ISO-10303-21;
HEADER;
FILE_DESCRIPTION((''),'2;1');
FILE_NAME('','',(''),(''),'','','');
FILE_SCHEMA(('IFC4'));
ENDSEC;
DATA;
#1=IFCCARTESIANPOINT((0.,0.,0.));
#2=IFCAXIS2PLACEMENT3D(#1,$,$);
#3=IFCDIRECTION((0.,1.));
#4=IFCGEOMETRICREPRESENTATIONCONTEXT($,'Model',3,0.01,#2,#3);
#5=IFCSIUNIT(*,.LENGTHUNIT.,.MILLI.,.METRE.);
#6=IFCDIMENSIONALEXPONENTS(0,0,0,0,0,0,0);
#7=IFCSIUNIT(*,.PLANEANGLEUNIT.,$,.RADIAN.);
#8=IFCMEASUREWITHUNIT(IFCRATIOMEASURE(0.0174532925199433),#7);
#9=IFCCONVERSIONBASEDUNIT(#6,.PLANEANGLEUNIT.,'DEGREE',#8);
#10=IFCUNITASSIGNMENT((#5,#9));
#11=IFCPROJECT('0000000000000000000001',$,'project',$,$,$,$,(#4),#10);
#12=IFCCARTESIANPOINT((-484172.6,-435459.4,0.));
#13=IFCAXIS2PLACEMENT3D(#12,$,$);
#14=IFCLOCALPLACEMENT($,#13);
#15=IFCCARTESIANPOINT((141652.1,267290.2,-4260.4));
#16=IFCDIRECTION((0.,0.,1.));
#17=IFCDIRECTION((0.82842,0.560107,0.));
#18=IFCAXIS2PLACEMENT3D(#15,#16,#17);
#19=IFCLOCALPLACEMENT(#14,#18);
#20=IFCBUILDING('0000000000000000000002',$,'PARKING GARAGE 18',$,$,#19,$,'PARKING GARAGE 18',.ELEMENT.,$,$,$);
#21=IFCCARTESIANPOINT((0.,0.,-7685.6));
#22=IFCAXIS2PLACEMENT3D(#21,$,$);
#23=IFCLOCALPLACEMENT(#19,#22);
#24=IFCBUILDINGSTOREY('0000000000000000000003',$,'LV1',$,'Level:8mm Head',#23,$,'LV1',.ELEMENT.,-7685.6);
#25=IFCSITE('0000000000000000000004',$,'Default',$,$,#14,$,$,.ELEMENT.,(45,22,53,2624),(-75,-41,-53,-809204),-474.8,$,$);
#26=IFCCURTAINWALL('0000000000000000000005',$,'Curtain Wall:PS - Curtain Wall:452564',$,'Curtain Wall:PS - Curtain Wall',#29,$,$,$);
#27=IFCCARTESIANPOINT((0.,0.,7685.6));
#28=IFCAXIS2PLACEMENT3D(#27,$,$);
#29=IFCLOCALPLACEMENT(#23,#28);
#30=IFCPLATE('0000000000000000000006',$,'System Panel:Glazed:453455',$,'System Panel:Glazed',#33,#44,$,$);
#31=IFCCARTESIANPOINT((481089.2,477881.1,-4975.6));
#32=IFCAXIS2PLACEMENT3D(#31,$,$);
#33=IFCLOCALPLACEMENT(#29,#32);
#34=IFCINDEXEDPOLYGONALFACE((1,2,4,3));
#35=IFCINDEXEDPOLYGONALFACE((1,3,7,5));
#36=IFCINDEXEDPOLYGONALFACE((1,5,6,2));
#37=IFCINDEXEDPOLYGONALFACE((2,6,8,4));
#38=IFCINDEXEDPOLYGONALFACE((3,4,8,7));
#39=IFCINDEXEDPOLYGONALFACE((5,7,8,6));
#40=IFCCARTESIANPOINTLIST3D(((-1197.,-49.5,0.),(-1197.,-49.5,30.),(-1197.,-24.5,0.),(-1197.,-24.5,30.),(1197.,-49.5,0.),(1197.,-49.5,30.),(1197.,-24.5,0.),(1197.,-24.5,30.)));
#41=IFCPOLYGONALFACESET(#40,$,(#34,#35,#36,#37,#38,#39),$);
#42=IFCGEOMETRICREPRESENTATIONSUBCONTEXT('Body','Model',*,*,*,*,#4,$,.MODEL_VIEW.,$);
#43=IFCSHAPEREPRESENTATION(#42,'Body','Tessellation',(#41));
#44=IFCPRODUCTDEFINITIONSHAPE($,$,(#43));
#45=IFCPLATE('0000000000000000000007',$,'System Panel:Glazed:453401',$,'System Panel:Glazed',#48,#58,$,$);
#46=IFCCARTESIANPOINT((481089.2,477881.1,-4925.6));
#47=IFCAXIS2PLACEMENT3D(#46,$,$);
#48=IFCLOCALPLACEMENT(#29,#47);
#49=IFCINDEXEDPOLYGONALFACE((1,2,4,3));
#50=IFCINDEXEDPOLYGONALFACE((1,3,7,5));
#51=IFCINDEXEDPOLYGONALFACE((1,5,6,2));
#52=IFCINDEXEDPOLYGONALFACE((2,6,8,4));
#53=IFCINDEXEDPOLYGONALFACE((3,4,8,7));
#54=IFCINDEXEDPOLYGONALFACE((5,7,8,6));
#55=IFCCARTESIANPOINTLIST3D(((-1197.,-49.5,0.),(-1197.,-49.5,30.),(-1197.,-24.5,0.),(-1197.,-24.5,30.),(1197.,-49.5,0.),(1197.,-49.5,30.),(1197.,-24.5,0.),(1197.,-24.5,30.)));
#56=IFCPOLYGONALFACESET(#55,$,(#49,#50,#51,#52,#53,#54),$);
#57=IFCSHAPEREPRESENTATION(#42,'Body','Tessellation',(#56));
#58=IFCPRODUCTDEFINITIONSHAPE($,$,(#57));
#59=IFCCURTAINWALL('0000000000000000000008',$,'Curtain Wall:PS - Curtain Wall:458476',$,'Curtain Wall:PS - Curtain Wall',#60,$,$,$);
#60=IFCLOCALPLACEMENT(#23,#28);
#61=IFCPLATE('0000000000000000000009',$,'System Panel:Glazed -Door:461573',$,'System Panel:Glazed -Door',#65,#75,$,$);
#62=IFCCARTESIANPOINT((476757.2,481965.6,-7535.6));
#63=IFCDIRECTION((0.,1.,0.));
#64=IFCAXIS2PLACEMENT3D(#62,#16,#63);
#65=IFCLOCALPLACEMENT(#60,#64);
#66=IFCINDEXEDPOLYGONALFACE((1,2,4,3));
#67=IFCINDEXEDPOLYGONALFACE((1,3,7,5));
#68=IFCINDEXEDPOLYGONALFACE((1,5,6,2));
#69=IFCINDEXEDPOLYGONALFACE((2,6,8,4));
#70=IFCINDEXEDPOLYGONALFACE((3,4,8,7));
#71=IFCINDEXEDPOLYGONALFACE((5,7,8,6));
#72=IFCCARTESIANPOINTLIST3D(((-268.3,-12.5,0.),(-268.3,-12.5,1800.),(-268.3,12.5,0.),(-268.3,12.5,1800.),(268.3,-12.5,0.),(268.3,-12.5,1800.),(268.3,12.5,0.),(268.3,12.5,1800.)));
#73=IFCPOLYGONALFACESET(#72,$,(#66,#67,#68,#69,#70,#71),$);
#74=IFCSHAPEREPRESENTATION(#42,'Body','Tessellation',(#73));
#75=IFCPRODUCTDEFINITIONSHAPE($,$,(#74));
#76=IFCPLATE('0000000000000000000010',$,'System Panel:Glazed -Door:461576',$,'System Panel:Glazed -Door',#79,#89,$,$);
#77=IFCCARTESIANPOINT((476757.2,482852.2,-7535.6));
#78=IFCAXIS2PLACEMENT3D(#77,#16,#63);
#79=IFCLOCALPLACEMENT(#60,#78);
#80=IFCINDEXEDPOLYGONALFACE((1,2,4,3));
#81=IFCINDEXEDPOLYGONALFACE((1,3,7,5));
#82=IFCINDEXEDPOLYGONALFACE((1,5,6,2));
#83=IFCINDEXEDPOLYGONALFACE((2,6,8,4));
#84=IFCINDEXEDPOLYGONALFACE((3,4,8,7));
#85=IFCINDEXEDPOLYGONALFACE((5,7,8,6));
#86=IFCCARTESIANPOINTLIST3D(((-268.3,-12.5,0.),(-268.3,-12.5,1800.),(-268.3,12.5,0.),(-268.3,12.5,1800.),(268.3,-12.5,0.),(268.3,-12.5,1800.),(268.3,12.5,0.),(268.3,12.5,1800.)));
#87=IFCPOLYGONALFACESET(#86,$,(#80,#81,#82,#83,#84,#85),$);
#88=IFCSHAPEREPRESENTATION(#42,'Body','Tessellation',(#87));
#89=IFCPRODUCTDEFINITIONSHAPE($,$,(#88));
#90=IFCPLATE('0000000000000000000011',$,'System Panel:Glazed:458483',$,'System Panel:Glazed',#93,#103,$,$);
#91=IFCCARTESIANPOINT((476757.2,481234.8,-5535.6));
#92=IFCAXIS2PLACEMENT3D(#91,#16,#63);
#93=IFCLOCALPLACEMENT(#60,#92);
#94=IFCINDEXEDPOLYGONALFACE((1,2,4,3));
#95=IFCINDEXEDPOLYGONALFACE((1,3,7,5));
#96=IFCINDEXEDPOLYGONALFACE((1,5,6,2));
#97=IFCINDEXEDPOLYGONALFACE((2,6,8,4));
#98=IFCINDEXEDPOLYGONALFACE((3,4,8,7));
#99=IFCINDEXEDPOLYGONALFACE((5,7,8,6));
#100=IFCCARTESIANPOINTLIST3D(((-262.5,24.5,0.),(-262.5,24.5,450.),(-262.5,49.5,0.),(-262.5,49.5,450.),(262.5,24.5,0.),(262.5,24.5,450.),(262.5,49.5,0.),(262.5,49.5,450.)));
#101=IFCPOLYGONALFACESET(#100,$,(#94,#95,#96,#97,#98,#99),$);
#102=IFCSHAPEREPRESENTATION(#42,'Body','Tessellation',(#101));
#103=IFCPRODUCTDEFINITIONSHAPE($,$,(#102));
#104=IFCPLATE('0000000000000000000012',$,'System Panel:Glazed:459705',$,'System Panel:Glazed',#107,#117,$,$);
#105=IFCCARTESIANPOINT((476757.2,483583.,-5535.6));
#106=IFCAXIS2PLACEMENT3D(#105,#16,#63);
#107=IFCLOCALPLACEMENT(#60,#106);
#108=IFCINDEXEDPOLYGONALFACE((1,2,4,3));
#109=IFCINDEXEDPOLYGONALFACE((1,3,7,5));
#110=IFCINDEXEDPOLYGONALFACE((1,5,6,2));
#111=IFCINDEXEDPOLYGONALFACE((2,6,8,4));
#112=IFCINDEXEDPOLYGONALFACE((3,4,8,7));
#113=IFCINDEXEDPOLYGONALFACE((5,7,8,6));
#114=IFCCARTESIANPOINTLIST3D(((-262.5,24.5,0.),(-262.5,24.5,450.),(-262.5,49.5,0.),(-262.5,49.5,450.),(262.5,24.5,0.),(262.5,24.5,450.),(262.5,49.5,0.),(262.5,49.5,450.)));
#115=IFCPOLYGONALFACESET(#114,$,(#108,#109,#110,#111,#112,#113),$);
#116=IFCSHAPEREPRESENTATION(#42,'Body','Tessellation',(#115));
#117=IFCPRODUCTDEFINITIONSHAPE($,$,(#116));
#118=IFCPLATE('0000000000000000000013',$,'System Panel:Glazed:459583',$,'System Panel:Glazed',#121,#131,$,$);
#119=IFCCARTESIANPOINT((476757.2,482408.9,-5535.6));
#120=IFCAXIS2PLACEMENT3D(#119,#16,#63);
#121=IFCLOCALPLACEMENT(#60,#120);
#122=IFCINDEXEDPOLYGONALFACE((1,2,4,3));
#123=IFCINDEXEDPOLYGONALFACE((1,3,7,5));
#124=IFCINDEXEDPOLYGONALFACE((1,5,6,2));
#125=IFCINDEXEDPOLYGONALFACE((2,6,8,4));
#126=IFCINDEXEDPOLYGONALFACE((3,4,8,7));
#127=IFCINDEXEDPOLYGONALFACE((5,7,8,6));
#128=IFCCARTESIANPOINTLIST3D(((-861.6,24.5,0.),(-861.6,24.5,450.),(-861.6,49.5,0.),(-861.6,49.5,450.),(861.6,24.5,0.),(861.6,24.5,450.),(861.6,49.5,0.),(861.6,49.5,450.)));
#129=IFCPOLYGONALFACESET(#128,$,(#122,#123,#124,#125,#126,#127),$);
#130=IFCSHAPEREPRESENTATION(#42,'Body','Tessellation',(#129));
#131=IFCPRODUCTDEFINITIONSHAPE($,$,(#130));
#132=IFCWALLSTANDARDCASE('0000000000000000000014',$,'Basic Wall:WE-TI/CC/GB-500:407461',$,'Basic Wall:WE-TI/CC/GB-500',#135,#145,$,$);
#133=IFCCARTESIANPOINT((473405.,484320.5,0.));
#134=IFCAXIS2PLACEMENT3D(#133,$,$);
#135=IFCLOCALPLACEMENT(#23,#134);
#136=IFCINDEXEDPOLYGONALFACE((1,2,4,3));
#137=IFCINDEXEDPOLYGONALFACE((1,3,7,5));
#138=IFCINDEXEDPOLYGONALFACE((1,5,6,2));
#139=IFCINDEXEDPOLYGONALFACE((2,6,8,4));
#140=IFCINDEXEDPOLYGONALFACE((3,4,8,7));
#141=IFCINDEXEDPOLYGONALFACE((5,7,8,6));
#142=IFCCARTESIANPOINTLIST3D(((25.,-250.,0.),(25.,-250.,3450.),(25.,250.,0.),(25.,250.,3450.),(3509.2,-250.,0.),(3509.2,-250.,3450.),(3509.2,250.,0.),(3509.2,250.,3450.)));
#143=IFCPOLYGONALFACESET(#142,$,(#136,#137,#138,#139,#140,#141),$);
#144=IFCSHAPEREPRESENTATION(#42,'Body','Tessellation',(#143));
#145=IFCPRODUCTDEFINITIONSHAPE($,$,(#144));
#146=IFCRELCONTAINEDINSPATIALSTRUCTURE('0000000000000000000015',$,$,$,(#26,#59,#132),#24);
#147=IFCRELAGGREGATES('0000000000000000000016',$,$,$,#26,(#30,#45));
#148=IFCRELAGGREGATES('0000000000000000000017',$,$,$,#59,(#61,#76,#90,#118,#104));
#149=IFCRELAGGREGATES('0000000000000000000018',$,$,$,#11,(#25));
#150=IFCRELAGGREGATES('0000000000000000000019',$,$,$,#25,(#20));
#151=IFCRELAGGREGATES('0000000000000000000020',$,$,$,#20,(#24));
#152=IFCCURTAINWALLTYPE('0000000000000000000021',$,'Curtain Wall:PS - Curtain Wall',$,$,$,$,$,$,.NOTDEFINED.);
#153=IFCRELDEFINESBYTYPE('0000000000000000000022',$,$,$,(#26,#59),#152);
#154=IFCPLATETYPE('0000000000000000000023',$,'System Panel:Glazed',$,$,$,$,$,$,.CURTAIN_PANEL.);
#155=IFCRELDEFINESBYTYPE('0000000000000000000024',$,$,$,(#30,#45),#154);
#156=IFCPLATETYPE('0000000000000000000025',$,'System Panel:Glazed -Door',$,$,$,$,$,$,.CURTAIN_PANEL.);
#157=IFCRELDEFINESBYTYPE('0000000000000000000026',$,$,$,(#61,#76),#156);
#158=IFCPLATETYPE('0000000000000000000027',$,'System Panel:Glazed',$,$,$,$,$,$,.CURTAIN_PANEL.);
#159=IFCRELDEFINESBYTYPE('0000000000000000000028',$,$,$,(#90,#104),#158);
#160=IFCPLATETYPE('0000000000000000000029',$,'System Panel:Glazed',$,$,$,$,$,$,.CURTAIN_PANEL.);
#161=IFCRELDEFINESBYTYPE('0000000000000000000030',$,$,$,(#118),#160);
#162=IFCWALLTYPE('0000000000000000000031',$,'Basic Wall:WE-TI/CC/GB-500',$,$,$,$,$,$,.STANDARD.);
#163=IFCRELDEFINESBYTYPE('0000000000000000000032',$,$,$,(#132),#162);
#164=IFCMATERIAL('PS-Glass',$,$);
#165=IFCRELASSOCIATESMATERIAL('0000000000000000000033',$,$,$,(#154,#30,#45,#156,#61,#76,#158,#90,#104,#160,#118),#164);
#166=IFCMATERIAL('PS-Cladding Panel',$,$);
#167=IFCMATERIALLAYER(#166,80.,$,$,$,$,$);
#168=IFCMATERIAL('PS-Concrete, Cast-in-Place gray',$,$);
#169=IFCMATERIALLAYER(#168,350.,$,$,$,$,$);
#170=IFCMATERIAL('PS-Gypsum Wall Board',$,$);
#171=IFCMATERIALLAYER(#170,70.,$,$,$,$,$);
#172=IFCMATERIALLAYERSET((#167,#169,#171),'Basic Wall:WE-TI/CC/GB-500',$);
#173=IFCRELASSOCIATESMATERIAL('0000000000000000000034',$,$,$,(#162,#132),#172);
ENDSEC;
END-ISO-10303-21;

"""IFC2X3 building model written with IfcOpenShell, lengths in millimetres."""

from ifc_helpers import new_model, entity, si_unit, converted_unit, direction, frame, frame_2d, origin, origin_2d_with_axis, place, context, subcontext, project, spatial, rectangle, extrude, source, transform, mapped, material, layer, layer_set, layer_usage, type_object, type_shapes, element, aggregate, save


model = new_model("IFC2X3")

# Units and contexts
model_context = context("Model", 3, precision=0.01, world=origin(), true_north=direction((0.0, 1.0)))
body_context = subcontext(model_context, "Body", "Model", "MODEL_VIEW")
ifc_project = project(units=[si_unit("LENGTHUNIT", "METRE", prefix="MILLI"), converted_unit("PLANEANGLEUNIT", "DEGREE", entity("IfcRatioMeasure", 0.0174532925199433), si_unit("PLANEANGLEUNIT", "RADIAN"), dimensions=[0, 0, 0, 0, 0, 0, 0])], contexts=[model_context])

# Site, building, storey
site_placement = place(None, frame((-484172.6, -435459.4, 0.0)))
site = spatial("IfcSite", under=ifc_project, at=site_placement, Name="Default", CompositionType="ELEMENT", RefLatitude=(45, 22, 53, 2624), RefLongitude=(-75, -41, -53, -809204), RefElevation=-474.8)
building_placement = place(site_placement, frame((141652.1, 267290.2, -4260.4), z_axis=(0.0, 0.0, 1.0), x_axis=(0.82842, 0.560107, 0.0)))
building = spatial("IfcBuilding", under=site, at=building_placement, Name="PARKING GARAGE 18", LongName="PARKING GARAGE 18", CompositionType="ELEMENT")
storey_placement = place(building_placement, frame((0.0, 0.0, -7685.6)))
storey = spatial("IfcBuildingStorey", under=building, at=storey_placement, Name="LV1", ObjectType="Level:8mm Head", LongName="LV1", CompositionType="ELEMENT", Elevation=-7685.6)

# Curtain walls, plates
curtain_wall_type = type_object("IfcCurtainWallType", Name="Curtain Wall:PS - Curtain Wall", PredefinedType="NOTDEFINED")
curtain_wall_1_placement = place(storey_placement, frame((0.0, 0.0, 7685.6)))
curtain_wall_1 = element("IfcCurtainWall", 1, at=curtain_wall_1_placement, inside=storey, type_object=curtain_wall_type, Name="Curtain Wall:PS - Curtain Wall:452564", ObjectType="Curtain Wall:PS - Curtain Wall")
ifc_material_1 = material(Name="PS-Glass")
plate_type_1 = type_object("IfcPlateType", Name="System Panel:Glazed", PredefinedType="CURTAIN_PANEL", material=ifc_material_1)
shared_shape_1 = source(origin(), body_context, "Body", "SweptSolid", [
    extrude(rectangle(XDim=25.0, YDim=2394.1, at=frame_2d((0.0, 0.0), x_axis=(1.0, 0.0))), frame((0.0, -37.0, 0.0), z_axis=(0.0, 0.0, 1.0), x_axis=(0.0, 1.0, 0.0)), (0.0, 0.0, 1.0), 30.0),
])
type_shapes(plate_type_1, [shared_shape_1])
plate_1_placement = place(curtain_wall_1_placement, frame((481089.2, 477881.1, -4975.6)))
plate_1 = element("IfcPlate", 2, at=plate_1_placement, type_object=plate_type_1, material=ifc_material_1, Name="System Panel:Glazed:453455", ObjectType="System Panel:Glazed", context=body_context, shape_type="MappedRepresentation", body=[
    mapped(shared_shape_1, transform((0.0, 0.0, 0.0), scale=1.0)),
])
plate_2_placement = place(curtain_wall_1_placement, frame((481089.2, 477881.1, -4925.6)))
plate_2 = element("IfcPlate", 3, at=plate_2_placement, type_object=plate_type_1, material=ifc_material_1, Name="System Panel:Glazed:453401", ObjectType="System Panel:Glazed", context=body_context, shape_type="MappedRepresentation", body=[
    mapped(shared_shape_1, transform((0.0, 0.0, 0.0), scale=1.0)),
])
aggregate(curtain_wall_1, [plate_1, plate_2])
curtain_wall_2_placement = place(storey_placement, frame((0.0, 0.0, 7685.6)))
curtain_wall_2 = element("IfcCurtainWall", 4, at=curtain_wall_2_placement, inside=storey, type_object=curtain_wall_type, Name="Curtain Wall:PS - Curtain Wall:458476", ObjectType="Curtain Wall:PS - Curtain Wall")
plate_type_2 = type_object("IfcPlateType", Name="System Panel:Glazed -Door", PredefinedType="CURTAIN_PANEL", material=ifc_material_1)
shared_shape_2 = source(origin(), body_context, "Body", "SweptSolid", [
    extrude(rectangle(XDim=25.0, YDim=536.6, at=origin_2d_with_axis()), frame((0.0, 0.0, 0.0), z_axis=(0.0, 0.0, 1.0), x_axis=(0.0, 1.0, 0.0)), (0.0, 0.0, 1.0), 1800.0),
])
type_shapes(plate_type_2, [shared_shape_2])
plate_3_placement = place(curtain_wall_2_placement, frame((476757.2, 481965.6, -7535.6), z_axis=(0.0, 0.0, 1.0), x_axis=(0.0, 1.0, 0.0)))
plate_3 = element("IfcPlate", 5, at=plate_3_placement, type_object=plate_type_2, material=ifc_material_1, Name="System Panel:Glazed -Door:461573", ObjectType="System Panel:Glazed -Door", context=body_context, shape_type="MappedRepresentation", body=[
    mapped(shared_shape_2, transform((0.0, 0.0, 0.0), scale=1.0)),
])
plate_4_placement = place(curtain_wall_2_placement, frame((476757.2, 482852.2, -7535.6), z_axis=(0.0, 0.0, 1.0), x_axis=(0.0, 1.0, 0.0)))
plate_4 = element("IfcPlate", 6, at=plate_4_placement, type_object=plate_type_2, material=ifc_material_1, Name="System Panel:Glazed -Door:461576", ObjectType="System Panel:Glazed -Door", context=body_context, shape_type="MappedRepresentation", body=[
    mapped(shared_shape_2, transform((0.0, 0.0, 0.0), scale=1.0)),
])
plate_type_3 = type_object("IfcPlateType", Name="System Panel:Glazed", PredefinedType="CURTAIN_PANEL", material=ifc_material_1)
shared_shape_3 = source(origin(), body_context, "Body", "SweptSolid", [
    extrude(rectangle(XDim=25.0, YDim=525.0, at=origin_2d_with_axis()), frame((0.0, 37.0, 0.0), z_axis=(0.0, 0.0, 1.0), x_axis=(0.0, 1.0, 0.0)), (0.0, 0.0, 1.0), 450.0),
])
type_shapes(plate_type_3, [shared_shape_3])
plate_5_placement = place(curtain_wall_2_placement, frame((476757.2, 481234.8, -5535.6), z_axis=(0.0, 0.0, 1.0), x_axis=(0.0, 1.0, 0.0)))
plate_5 = element("IfcPlate", 7, at=plate_5_placement, type_object=plate_type_3, material=ifc_material_1, Name="System Panel:Glazed:458483", ObjectType="System Panel:Glazed", context=body_context, shape_type="MappedRepresentation", body=[
    mapped(shared_shape_3, transform((0.0, 0.0, 0.0), scale=1.0)),
])
plate_6_placement = place(curtain_wall_2_placement, frame((476757.2, 483583.0, -5535.6), z_axis=(0.0, 0.0, 1.0), x_axis=(0.0, 1.0, 0.0)))
plate_6 = element("IfcPlate", 8, at=plate_6_placement, type_object=plate_type_3, material=ifc_material_1, Name="System Panel:Glazed:459705", ObjectType="System Panel:Glazed", context=body_context, shape_type="MappedRepresentation", body=[
    mapped(shared_shape_3, transform((0.0, 0.0, 0.0), scale=1.0)),
])
plate_type_4 = type_object("IfcPlateType", Name="System Panel:Glazed", PredefinedType="CURTAIN_PANEL", material=ifc_material_1)
shared_shape_4 = source(origin(), body_context, "Body", "SweptSolid", [
    extrude(rectangle(XDim=450.0, YDim=1723.2, at=origin_2d_with_axis()), frame((0.0, 24.5, 225.0), z_axis=(0.0, 1.0, 0.0), x_axis=(0.0, 0.0, 1.0)), (0.0, 0.0, 1.0), 25.0),
])
type_shapes(plate_type_4, [shared_shape_4])
plate_7_placement = place(curtain_wall_2_placement, frame((476757.2, 482408.9, -5535.6), z_axis=(0.0, 0.0, 1.0), x_axis=(0.0, 1.0, 0.0)))
plate_7 = element("IfcPlate", 9, at=plate_7_placement, type_object=plate_type_4, material=ifc_material_1, Name="System Panel:Glazed:459583", ObjectType="System Panel:Glazed", context=body_context, shape_type="MappedRepresentation", body=[
    mapped(shared_shape_4, transform((0.0, 0.0, 0.0), scale=1.0)),
])
aggregate(curtain_wall_2, [plate_3, plate_4, plate_5, plate_7, plate_6])

# Wall
ifc_material_2 = material(Name="PS-Cladding Panel")
ifc_layer_1 = layer(ifc_material_2, 80.0)
ifc_material_3 = material(Name="PS-Concrete, Cast-in-Place gray")
ifc_layer_2 = layer(ifc_material_3, 350.0)
ifc_material_4 = material(Name="PS-Gypsum Wall Board")
ifc_layer_3 = layer(ifc_material_4, 70.0)
ifc_layer_set_1 = layer_set([ifc_layer_1, ifc_layer_2, ifc_layer_3], Name="Basic Wall:WE-TI/CC/GB-500")
ifc_layer_usage_1 = layer_usage(ifc_layer_set_1, "AXIS2", "POSITIVE", -250.0)
wall_type_1 = type_object("IfcWallType", Name="Basic Wall:WE-TI/CC/GB-500", PredefinedType="STANDARD", material=ifc_layer_set_1)
wall_1_placement = place(storey_placement, frame((473405.0, 484320.5, 0.0)))
element("IfcWallStandardCase", 10, at=wall_1_placement, inside=storey, type_object=wall_type_1, material=ifc_layer_usage_1, Name="Basic Wall:WE-TI/CC/GB-500:407461", ObjectType="Basic Wall:WE-TI/CC/GB-500", context=body_context, shape_type="SweptSolid", body=[
    extrude(rectangle(XDim=3484.2, YDim=500.0, at=frame_2d((1767.1, 0.0), x_axis=(-1.0, 0.0))), origin(), (0.0, 0.0, 1.0), 3450.0),
])

save(model, "model.ifc")
